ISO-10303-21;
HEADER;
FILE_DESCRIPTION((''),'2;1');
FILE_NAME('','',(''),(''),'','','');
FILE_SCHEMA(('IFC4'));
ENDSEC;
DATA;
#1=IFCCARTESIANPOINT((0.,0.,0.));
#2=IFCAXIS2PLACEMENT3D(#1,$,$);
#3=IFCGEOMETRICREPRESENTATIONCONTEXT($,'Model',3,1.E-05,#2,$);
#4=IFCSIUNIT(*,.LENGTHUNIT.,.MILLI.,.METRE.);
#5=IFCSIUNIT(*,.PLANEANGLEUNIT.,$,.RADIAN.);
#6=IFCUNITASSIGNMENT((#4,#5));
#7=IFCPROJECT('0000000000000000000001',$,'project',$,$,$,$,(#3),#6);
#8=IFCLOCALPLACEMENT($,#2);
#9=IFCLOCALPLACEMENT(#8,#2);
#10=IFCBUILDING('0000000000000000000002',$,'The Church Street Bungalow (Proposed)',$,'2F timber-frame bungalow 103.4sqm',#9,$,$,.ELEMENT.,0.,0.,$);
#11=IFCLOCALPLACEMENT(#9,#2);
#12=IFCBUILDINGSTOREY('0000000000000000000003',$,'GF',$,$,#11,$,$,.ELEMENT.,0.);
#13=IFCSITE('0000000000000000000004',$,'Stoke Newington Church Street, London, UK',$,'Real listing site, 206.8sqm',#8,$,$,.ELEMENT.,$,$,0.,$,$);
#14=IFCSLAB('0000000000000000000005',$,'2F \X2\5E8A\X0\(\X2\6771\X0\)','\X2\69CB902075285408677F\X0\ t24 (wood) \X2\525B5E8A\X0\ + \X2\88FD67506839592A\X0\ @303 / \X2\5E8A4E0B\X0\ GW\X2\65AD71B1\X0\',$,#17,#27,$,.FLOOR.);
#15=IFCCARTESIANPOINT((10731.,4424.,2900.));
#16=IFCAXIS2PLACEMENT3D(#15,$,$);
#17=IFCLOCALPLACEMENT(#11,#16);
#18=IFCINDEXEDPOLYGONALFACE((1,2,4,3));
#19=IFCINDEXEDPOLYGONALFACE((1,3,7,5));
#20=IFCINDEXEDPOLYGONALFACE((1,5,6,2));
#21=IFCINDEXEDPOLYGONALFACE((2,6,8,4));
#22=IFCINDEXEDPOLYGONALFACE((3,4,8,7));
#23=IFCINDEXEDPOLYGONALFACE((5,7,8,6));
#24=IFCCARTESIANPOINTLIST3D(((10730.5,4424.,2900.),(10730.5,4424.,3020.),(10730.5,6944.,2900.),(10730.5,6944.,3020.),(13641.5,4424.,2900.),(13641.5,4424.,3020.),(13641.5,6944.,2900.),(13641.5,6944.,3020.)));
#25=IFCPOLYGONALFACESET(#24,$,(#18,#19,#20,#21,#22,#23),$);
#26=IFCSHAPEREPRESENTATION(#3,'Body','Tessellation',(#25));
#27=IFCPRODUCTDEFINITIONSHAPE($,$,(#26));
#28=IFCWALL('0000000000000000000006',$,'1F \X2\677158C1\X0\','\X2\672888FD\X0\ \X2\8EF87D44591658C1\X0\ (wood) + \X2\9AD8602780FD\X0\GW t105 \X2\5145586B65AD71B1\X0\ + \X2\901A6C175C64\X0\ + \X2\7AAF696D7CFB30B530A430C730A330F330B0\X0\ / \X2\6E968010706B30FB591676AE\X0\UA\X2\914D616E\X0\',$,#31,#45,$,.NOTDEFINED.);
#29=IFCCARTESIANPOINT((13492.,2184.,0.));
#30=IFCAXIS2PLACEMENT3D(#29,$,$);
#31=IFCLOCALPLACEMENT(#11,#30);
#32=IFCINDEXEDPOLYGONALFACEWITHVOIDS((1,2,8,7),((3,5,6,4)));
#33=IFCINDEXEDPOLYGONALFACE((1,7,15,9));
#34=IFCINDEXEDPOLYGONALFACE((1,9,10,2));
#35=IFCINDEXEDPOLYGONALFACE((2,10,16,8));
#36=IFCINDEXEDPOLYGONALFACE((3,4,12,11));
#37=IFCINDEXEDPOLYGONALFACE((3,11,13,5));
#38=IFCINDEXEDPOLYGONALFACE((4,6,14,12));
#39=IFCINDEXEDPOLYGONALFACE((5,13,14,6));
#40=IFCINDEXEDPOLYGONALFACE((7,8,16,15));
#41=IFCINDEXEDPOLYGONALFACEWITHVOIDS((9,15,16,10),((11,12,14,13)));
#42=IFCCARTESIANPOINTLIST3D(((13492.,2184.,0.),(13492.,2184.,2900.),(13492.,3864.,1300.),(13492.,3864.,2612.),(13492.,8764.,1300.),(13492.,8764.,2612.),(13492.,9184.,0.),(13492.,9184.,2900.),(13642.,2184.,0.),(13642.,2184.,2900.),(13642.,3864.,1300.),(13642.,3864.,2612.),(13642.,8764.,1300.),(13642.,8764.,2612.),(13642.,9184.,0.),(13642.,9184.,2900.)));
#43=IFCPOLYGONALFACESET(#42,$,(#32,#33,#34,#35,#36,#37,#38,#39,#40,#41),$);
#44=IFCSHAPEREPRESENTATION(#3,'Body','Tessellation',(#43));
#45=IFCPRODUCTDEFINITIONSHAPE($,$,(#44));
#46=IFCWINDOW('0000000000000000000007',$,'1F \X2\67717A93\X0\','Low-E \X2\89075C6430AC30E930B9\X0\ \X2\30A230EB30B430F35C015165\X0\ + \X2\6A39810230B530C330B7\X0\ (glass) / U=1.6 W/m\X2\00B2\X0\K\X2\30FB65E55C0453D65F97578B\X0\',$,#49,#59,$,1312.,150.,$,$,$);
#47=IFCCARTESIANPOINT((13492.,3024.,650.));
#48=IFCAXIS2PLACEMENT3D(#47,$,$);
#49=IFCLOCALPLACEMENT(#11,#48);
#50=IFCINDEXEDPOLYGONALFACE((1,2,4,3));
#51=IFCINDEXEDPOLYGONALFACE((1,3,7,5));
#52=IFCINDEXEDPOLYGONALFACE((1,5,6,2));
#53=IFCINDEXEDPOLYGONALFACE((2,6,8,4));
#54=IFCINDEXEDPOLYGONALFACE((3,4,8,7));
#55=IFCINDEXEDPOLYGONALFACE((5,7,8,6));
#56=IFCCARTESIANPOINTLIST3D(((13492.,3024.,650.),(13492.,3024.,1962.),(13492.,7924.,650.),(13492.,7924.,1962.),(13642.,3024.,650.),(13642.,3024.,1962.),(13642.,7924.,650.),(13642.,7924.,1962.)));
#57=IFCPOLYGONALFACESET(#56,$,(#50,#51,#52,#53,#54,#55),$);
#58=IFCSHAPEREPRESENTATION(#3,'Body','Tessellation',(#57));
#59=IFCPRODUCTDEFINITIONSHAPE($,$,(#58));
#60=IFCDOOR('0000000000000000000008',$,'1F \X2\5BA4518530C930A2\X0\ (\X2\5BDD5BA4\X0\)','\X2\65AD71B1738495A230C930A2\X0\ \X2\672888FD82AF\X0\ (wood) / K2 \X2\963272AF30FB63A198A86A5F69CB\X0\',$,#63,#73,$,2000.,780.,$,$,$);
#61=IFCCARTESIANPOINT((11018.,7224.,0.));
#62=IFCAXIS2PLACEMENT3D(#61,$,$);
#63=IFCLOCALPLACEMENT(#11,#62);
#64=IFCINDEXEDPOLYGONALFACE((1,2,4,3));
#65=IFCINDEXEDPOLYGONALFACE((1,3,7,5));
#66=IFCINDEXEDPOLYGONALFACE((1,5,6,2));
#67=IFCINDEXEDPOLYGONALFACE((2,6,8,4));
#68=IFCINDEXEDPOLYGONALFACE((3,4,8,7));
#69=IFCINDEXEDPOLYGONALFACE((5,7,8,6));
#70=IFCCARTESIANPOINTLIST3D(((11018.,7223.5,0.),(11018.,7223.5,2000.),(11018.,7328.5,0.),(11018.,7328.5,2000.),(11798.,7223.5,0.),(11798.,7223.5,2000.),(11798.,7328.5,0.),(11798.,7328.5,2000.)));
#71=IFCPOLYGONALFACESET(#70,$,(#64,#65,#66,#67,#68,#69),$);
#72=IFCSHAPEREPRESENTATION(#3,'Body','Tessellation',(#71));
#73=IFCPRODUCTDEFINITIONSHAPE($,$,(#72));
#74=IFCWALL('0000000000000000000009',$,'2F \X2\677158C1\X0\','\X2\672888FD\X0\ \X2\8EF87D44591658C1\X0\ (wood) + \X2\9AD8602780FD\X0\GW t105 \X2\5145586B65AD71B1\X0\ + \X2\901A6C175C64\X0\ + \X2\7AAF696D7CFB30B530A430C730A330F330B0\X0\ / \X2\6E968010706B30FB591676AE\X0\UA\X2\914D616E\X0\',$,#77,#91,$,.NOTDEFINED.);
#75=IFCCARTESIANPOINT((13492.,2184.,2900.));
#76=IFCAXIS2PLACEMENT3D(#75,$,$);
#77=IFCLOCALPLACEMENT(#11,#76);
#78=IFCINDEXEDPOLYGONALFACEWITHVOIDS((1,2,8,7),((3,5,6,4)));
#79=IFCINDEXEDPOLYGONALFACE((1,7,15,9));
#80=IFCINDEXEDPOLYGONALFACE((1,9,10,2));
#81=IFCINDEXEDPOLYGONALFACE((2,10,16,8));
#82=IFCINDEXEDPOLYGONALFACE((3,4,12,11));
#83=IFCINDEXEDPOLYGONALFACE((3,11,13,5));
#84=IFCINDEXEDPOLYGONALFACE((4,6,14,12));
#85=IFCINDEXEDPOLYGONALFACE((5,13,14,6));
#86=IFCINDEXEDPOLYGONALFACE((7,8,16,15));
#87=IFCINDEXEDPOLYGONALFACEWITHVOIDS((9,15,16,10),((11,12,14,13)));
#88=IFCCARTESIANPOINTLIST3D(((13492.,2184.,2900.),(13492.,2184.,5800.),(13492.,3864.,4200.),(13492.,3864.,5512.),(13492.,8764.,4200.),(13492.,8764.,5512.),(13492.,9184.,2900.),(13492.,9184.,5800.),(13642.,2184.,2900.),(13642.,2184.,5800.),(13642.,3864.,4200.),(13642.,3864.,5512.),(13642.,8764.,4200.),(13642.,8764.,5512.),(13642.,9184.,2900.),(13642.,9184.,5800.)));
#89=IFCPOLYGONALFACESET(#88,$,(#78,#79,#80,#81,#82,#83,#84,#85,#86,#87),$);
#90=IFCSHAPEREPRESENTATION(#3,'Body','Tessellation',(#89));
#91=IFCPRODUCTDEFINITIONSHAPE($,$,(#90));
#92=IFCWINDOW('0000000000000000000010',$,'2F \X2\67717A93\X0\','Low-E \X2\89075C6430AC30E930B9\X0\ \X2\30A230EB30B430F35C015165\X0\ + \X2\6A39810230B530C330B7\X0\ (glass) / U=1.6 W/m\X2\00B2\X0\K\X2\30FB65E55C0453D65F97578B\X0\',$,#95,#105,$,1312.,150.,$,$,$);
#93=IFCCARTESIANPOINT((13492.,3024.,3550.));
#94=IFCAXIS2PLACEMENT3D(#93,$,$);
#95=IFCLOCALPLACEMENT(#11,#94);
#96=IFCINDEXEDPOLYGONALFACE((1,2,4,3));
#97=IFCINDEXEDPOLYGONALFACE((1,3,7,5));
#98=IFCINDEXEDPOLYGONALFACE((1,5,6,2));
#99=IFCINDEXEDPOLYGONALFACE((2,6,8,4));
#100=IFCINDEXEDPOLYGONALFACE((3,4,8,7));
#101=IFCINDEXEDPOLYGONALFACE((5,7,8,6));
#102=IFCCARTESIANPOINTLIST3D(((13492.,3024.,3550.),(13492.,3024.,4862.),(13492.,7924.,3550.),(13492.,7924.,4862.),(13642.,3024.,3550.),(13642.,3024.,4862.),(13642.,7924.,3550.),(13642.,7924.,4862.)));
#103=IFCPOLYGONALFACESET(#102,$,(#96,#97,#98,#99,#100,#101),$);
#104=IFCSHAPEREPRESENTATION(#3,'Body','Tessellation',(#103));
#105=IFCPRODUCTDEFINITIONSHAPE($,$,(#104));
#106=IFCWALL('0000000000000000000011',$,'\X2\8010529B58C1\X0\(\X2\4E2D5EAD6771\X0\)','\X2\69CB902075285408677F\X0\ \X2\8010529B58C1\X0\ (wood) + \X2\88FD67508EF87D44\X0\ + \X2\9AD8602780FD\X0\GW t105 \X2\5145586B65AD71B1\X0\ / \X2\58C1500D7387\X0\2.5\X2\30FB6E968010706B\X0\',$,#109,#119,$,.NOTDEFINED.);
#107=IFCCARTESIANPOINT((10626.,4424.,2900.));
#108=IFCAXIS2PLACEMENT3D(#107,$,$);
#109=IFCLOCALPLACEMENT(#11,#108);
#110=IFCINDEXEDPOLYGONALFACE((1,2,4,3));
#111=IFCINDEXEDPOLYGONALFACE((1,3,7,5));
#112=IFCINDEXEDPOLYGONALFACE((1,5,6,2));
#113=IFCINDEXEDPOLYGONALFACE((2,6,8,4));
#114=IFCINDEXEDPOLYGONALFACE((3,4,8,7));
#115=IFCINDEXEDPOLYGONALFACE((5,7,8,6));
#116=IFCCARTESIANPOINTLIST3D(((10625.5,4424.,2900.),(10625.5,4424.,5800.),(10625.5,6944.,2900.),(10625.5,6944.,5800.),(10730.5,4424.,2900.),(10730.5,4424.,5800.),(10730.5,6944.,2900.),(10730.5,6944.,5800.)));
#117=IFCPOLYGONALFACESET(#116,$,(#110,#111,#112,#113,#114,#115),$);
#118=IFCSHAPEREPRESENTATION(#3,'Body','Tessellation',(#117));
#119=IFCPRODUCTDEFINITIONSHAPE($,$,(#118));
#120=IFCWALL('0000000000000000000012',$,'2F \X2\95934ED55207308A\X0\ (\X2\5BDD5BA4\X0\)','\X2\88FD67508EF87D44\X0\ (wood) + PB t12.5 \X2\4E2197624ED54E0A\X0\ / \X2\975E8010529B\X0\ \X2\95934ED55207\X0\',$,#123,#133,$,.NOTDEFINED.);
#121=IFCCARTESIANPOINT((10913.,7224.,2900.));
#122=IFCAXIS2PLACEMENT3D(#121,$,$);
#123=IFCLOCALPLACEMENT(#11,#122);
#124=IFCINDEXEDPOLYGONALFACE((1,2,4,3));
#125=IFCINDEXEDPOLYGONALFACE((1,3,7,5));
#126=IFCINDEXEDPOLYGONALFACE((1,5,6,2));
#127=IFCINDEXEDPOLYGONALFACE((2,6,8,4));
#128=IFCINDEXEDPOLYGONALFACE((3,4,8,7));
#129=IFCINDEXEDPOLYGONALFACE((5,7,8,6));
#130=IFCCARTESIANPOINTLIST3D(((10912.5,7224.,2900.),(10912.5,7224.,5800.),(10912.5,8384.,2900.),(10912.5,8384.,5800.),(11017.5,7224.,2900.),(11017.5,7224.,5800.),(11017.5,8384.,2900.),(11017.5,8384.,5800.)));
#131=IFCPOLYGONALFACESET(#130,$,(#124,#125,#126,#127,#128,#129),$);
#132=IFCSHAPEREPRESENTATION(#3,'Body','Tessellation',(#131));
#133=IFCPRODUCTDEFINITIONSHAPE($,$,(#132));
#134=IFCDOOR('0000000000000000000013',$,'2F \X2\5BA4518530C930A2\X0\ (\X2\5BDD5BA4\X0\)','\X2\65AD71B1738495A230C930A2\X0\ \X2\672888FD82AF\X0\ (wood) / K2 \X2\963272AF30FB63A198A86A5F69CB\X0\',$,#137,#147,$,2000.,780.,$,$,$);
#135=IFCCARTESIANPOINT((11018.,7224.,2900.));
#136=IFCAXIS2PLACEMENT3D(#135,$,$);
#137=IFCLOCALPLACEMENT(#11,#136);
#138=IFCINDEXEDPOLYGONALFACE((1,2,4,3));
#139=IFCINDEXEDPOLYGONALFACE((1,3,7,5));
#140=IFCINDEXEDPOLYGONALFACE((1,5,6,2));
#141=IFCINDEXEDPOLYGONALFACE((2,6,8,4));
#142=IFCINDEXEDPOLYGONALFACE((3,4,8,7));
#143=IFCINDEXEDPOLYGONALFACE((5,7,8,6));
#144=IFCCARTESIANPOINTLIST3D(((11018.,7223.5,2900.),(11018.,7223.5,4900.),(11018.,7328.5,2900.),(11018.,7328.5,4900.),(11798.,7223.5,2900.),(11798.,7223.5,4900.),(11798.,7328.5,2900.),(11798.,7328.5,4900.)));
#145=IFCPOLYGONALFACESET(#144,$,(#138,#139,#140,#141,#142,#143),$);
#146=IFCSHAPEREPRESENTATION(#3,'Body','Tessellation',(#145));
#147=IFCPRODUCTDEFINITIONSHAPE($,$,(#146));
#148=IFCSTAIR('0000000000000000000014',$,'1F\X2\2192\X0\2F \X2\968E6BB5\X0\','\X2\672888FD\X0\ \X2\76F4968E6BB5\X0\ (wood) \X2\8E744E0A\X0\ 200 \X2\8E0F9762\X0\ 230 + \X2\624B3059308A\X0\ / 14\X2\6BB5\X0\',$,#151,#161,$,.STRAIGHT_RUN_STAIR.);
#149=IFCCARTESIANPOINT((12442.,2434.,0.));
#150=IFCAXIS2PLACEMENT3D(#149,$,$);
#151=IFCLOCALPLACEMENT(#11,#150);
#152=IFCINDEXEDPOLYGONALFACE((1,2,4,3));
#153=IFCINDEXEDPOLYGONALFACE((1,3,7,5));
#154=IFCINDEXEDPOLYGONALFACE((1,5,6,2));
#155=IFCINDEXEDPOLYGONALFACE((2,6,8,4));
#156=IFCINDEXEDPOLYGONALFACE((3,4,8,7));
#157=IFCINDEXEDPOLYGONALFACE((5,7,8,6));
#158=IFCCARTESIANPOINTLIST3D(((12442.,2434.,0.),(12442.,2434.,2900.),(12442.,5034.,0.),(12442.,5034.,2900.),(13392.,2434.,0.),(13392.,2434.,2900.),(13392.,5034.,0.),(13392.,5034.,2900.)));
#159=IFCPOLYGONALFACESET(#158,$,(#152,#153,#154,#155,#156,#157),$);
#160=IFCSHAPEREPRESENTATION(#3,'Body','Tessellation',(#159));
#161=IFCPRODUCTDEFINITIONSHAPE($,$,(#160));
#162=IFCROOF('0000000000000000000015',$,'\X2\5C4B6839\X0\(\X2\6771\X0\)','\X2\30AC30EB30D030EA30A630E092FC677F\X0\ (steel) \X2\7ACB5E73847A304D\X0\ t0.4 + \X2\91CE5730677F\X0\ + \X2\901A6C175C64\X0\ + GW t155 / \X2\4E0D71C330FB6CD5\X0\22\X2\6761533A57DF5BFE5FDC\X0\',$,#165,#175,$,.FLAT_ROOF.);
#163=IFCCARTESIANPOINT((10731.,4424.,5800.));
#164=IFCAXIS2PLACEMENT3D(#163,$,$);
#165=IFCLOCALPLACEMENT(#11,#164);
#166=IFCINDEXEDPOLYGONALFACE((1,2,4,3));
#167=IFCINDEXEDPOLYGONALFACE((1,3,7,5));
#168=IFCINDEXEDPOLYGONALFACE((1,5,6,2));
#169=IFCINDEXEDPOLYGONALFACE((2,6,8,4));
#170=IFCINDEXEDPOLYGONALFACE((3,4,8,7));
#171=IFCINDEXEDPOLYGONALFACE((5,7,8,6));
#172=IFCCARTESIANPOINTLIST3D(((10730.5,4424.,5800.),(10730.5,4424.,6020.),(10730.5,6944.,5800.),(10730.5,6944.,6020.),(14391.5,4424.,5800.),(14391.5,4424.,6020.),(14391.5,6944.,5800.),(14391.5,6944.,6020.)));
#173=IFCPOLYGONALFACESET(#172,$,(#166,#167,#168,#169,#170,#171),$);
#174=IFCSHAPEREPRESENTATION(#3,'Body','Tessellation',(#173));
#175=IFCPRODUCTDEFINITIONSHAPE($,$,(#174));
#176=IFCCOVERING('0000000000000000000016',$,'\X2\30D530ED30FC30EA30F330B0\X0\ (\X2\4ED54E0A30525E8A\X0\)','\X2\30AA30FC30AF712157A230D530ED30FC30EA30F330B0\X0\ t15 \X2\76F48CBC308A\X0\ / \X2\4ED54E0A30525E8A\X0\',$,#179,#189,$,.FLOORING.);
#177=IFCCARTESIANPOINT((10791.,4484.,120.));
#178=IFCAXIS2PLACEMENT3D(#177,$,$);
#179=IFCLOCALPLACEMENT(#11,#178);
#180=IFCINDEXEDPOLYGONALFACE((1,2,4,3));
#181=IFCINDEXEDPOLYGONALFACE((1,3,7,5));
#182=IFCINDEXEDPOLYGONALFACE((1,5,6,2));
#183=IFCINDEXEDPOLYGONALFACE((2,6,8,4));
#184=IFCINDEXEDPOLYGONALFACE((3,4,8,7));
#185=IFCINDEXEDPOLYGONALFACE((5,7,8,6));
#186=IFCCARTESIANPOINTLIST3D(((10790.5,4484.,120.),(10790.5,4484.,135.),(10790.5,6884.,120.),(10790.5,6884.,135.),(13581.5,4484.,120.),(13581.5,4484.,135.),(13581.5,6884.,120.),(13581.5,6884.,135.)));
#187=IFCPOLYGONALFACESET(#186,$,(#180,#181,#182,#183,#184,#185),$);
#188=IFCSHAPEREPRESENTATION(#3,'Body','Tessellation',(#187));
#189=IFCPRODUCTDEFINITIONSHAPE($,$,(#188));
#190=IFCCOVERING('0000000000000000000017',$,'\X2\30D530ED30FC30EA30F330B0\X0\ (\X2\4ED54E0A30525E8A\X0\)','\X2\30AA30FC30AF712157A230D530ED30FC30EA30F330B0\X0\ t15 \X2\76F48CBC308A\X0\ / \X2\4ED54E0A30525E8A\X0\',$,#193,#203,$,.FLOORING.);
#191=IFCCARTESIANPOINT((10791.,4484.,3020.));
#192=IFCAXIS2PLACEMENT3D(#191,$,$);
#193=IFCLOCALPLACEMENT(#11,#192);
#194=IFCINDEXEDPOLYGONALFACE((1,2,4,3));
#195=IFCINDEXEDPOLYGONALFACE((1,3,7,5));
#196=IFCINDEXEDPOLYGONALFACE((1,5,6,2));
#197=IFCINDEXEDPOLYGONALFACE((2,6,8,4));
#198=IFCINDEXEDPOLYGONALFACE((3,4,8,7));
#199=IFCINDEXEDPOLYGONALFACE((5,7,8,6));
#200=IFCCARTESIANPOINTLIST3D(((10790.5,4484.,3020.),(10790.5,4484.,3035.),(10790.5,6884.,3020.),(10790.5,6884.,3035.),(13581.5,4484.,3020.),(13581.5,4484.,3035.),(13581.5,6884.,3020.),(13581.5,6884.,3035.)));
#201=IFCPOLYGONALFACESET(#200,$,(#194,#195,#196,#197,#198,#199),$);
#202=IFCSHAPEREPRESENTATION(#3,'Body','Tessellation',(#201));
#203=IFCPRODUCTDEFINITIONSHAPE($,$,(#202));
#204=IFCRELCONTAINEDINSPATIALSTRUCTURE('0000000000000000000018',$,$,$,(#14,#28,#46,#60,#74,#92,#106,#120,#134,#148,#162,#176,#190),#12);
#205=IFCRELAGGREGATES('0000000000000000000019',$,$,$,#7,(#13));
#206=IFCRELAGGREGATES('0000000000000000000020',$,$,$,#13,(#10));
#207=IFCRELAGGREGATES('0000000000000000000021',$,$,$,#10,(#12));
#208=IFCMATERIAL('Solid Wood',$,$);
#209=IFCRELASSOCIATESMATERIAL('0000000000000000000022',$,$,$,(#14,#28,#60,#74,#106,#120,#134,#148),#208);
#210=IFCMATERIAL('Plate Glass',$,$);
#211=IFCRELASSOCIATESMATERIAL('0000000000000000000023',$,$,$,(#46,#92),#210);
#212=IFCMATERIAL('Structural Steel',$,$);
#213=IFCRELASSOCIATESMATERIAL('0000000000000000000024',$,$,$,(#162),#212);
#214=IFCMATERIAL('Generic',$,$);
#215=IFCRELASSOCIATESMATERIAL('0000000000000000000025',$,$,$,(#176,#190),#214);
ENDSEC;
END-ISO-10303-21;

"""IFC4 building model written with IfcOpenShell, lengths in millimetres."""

from ifc_helpers import new_model, si_unit, frame, frame_2d, origin, place, context, project, spatial, rectangle, extrude, material, element, fill, save


model = new_model("IFC4")

# Units and contexts
model_context = context("Model", 3, precision=1e-05, world=origin())
ifc_project = project(units=[si_unit("LENGTHUNIT", "METRE", prefix="MILLI"), si_unit("PLANEANGLEUNIT", "RADIAN")], contexts=[model_context])

# Site, building, storey
site_placement = place(None, origin())
site = spatial("IfcSite", under=ifc_project, at=site_placement, Name="Stoke Newington Church Street, London, UK", ObjectType="Real listing site, 206.8sqm", CompositionType="ELEMENT", RefElevation=0.0)
building_placement = place(site_placement, origin())
building = spatial("IfcBuilding", under=site, at=building_placement, Name="The Church Street Bungalow (Proposed)", ObjectType="2F timber-frame bungalow 103.4sqm", CompositionType="ELEMENT", ElevationOfRefHeight=0.0, ElevationOfTerrain=0.0)
storey_placement = place(building_placement, origin())
storey = spatial("IfcBuildingStorey", under=building, at=storey_placement, Name="GF", CompositionType="ELEMENT", Elevation=0.0)

# Slab
ifc_material_1 = material(Name="Solid Wood")
slab_1_placement = place(storey_placement, frame((10731.0, 4424.0, 2900.0)))
element("IfcSlab", 1, at=slab_1_placement, inside=storey, material=ifc_material_1, Name="2F 床(東)", Description="構造用合板 t24 (wood) 剛床 + 製材根太 @303 / 床下 GW断熱", PredefinedType="FLOOR", context=model_context, shape_type="SweptSolid", body=[
    extrude(rectangle(XDim=2911.0, YDim=2520.0, at=frame_2d((1455.0, 1260.0))), frame((10731.0, 4424.0, 2900.0)), (0.0, 0.0, 1.0), 120.0),
])

# Wall, opening, window
wall_1_placement = place(storey_placement, frame((13492.0, 2184.0, 0.0)))
wall_1 = element("IfcWall", 2, at=wall_1_placement, inside=storey, material=ifc_material_1, Name="1F 東壁", Description="木製 軸組外壁 (wood) + 高性能GW t105 充填断熱 + 通気層 + 窯業系サイディング / 準耐火・外皮UA配慮", PredefinedType="NOTDEFINED", context=model_context, shape_type="SweptSolid", body=[
    extrude(rectangle(XDim=150.0, YDim=7000.0, at=frame_2d((75.0, 3500.0))), frame((13492.0, 2184.0, 0.0)), (0.0, 0.0, 1.0), 2900.0),
])
opening_1_placement = place(storey_placement, frame((13492.0, 3024.0, 650.0)))
opening_1 = element("IfcOpeningElement", 3, at=opening_1_placement, cuts=wall_1, PredefinedType="NOTDEFINED", context=model_context, shape_type="SweptSolid", body=[
    extrude(rectangle(XDim=150.0, YDim=4900.0, at=frame_2d((75.0, 2450.0))), frame((13492.0, 3024.0, 650.0)), (0.0, 0.0, 1.0), 1312.0),
])
ifc_material_2 = material(Name="Plate Glass")
window_1_placement = place(storey_placement, frame((13492.0, 3024.0, 650.0)))
window_1 = element("IfcWindow", 4, at=window_1_placement, inside=storey, material=ifc_material_2, Name="1F 東窓", Description="Low-E 複層ガラス アルゴン封入 + 樹脂サッシ (glass) / U=1.6 W/m²K・日射取得型", OverallHeight=1312.0, OverallWidth=150.0, context=model_context, shape_type="SweptSolid", body=[
    extrude(rectangle(XDim=150.0, YDim=4900.0, at=frame_2d((75.0, 2450.0))), frame((13492.0, 3024.0, 650.0)), (0.0, 0.0, 1.0), 1312.0),
])
fill(opening_1, window_1)

# Door
door_1_placement = place(storey_placement, frame((11018.0, 7224.0, 0.0)))
element("IfcDoor", 5, at=door_1_placement, inside=storey, material=ifc_material_1, Name="1F 室内ドア (寝室)", Description="断熱玄関ドア 木製芯 (wood) / K2 防犯・採風機構", OverallHeight=2000.0, OverallWidth=780.0, context=model_context, shape_type="SweptSolid", body=[
    extrude(rectangle(XDim=780.0, YDim=105.0, at=frame_2d((390.0, 52.0))), frame((11018.0, 7224.0, 0.0)), (0.0, 0.0, 1.0), 2000.0),
])

# Wall, opening, window
wall_2_placement = place(storey_placement, frame((13492.0, 2184.0, 2900.0)))
wall_2 = element("IfcWall", 6, at=wall_2_placement, inside=storey, material=ifc_material_1, Name="2F 東壁", Description="木製 軸組外壁 (wood) + 高性能GW t105 充填断熱 + 通気層 + 窯業系サイディング / 準耐火・外皮UA配慮", PredefinedType="NOTDEFINED", context=model_context, shape_type="SweptSolid", body=[
    extrude(rectangle(XDim=150.0, YDim=7000.0, at=frame_2d((75.0, 3500.0))), frame((13492.0, 2184.0, 2900.0)), (0.0, 0.0, 1.0), 2900.0),
])
opening_2_placement = place(storey_placement, frame((13492.0, 3024.0, 3550.0)))
opening_2 = element("IfcOpeningElement", 7, at=opening_2_placement, cuts=wall_2, PredefinedType="NOTDEFINED", context=model_context, shape_type="SweptSolid", body=[
    extrude(rectangle(XDim=150.0, YDim=4900.0, at=frame_2d((75.0, 2450.0))), frame((13492.0, 3024.0, 3550.0)), (0.0, 0.0, 1.0), 1312.0),
])
window_2_placement = place(storey_placement, frame((13492.0, 3024.0, 3550.0)))
window_2 = element("IfcWindow", 8, at=window_2_placement, inside=storey, material=ifc_material_2, Name="2F 東窓", Description="Low-E 複層ガラス アルゴン封入 + 樹脂サッシ (glass) / U=1.6 W/m²K・日射取得型", OverallHeight=1312.0, OverallWidth=150.0, context=model_context, shape_type="SweptSolid", body=[
    extrude(rectangle(XDim=150.0, YDim=4900.0, at=frame_2d((75.0, 2450.0))), frame((13492.0, 3024.0, 3550.0)), (0.0, 0.0, 1.0), 1312.0),
])
fill(opening_2, window_2)

# Walls
wall_3_placement = place(storey_placement, frame((10626.0, 4424.0, 2900.0)))
element("IfcWall", 9, at=wall_3_placement, inside=storey, material=ifc_material_1, Name="耐力壁(中庭東)", Description="構造用合板 耐力壁 (wood) + 製材軸組 + 高性能GW t105 充填断熱 / 壁倍率2.5・準耐火", PredefinedType="NOTDEFINED", context=model_context, shape_type="SweptSolid", body=[
    extrude(rectangle(XDim=105.0, YDim=2520.0, at=frame_2d((52.0, 1260.0))), frame((10626.0, 4424.0, 2900.0)), (0.0, 0.0, 1.0), 2900.0),
])
wall_4_placement = place(storey_placement, frame((10913.0, 7224.0, 2900.0)))
element("IfcWall", 10, at=wall_4_placement, inside=storey, material=ifc_material_1, Name="2F 間仕切り (寝室)", Description="製材軸組 (wood) + PB t12.5 両面仕上 / 非耐力 間仕切", PredefinedType="NOTDEFINED", context=model_context, shape_type="SweptSolid", body=[
    extrude(rectangle(XDim=105.0, YDim=1160.0, at=frame_2d((52.0, 580.0))), frame((10913.0, 7224.0, 2900.0)), (0.0, 0.0, 1.0), 2900.0),
])

# Door
door_2_placement = place(storey_placement, frame((11018.0, 7224.0, 2900.0)))
element("IfcDoor", 11, at=door_2_placement, inside=storey, material=ifc_material_1, Name="2F 室内ドア (寝室)", Description="断熱玄関ドア 木製芯 (wood) / K2 防犯・採風機構", OverallHeight=2000.0, OverallWidth=780.0, context=model_context, shape_type="SweptSolid", body=[
    extrude(rectangle(XDim=780.0, YDim=105.0, at=frame_2d((390.0, 52.0))), frame((11018.0, 7224.0, 2900.0)), (0.0, 0.0, 1.0), 2000.0),
])

# Stair
stair_placement = place(storey_placement, frame((12442.0, 2434.0, 0.0)))
element("IfcStair", 12, at=stair_placement, inside=storey, material=ifc_material_1, Name="1F→2F 階段", Description="木製 直階段 (wood) 蹴上 200 踏面 230 + 手すり / 14段", PredefinedType="STRAIGHT_RUN_STAIR", context=model_context, shape_type="SweptSolid", body=[
    extrude(rectangle(XDim=950.0, YDim=2600.0, at=frame_2d((475.0, 1300.0))), frame((12442.0, 2434.0, 0.0)), (0.0, 0.0, 1.0), 2900.0),
])

# Roof
ifc_material_3 = material(Name="Structural Steel")
for number, where, name in (
    (13, (10731.0, 4424.0, 5800.0), "屋根(東)"),
):
    element("IfcRoof", number, at=place(storey_placement, frame(where)), inside=storey, material=ifc_material_3, Name=name, Description="ガルバリウム鋼板 (steel) 立平葺き t0.4 + 野地板 + 通気層 + GW t155 / 不燃・法22条区域対応", PredefinedType="FLAT_ROOF", context=model_context, shape_type="SweptSolid", body=[
        extrude(rectangle(XDim=3661.0, YDim=2520.0, at=frame_2d((1830.0, 1260.0))), frame((10731.0, 4424.0, 5800.0)), (0.0, 0.0, 1.0), 220.0),
    ])

# Coverings
ifc_material_4 = material(Name="Generic")
covering_1_placement = place(storey_placement, frame((10791.0, 4484.0, 120.0)))
element("IfcCovering", 14, at=covering_1_placement, inside=storey, material=ifc_material_4, Name="フローリング (仕上げ床)", Description="オーク無垢フローリング t15 直貼り / 仕上げ床", PredefinedType="FLOORING", context=model_context, shape_type="SweptSolid", body=[
    extrude(rectangle(XDim=2791.0, YDim=2400.0, at=frame_2d((1395.0, 1200.0))), frame((10791.0, 4484.0, 120.0)), (0.0, 0.0, 1.0), 15.0),
])
covering_2_placement = place(storey_placement, frame((10791.0, 4484.0, 3020.0)))
element("IfcCovering", 15, at=covering_2_placement, inside=storey, material=ifc_material_4, Name="フローリング (仕上げ床)", Description="オーク無垢フローリング t15 直貼り / 仕上げ床", PredefinedType="FLOORING", context=model_context, shape_type="SweptSolid", body=[
    extrude(rectangle(XDim=2791.0, YDim=2400.0, at=frame_2d((1395.0, 1200.0))), frame((10791.0, 4484.0, 3020.0)), (0.0, 0.0, 1.0), 15.0),
])

save(model, "model.ifc")
